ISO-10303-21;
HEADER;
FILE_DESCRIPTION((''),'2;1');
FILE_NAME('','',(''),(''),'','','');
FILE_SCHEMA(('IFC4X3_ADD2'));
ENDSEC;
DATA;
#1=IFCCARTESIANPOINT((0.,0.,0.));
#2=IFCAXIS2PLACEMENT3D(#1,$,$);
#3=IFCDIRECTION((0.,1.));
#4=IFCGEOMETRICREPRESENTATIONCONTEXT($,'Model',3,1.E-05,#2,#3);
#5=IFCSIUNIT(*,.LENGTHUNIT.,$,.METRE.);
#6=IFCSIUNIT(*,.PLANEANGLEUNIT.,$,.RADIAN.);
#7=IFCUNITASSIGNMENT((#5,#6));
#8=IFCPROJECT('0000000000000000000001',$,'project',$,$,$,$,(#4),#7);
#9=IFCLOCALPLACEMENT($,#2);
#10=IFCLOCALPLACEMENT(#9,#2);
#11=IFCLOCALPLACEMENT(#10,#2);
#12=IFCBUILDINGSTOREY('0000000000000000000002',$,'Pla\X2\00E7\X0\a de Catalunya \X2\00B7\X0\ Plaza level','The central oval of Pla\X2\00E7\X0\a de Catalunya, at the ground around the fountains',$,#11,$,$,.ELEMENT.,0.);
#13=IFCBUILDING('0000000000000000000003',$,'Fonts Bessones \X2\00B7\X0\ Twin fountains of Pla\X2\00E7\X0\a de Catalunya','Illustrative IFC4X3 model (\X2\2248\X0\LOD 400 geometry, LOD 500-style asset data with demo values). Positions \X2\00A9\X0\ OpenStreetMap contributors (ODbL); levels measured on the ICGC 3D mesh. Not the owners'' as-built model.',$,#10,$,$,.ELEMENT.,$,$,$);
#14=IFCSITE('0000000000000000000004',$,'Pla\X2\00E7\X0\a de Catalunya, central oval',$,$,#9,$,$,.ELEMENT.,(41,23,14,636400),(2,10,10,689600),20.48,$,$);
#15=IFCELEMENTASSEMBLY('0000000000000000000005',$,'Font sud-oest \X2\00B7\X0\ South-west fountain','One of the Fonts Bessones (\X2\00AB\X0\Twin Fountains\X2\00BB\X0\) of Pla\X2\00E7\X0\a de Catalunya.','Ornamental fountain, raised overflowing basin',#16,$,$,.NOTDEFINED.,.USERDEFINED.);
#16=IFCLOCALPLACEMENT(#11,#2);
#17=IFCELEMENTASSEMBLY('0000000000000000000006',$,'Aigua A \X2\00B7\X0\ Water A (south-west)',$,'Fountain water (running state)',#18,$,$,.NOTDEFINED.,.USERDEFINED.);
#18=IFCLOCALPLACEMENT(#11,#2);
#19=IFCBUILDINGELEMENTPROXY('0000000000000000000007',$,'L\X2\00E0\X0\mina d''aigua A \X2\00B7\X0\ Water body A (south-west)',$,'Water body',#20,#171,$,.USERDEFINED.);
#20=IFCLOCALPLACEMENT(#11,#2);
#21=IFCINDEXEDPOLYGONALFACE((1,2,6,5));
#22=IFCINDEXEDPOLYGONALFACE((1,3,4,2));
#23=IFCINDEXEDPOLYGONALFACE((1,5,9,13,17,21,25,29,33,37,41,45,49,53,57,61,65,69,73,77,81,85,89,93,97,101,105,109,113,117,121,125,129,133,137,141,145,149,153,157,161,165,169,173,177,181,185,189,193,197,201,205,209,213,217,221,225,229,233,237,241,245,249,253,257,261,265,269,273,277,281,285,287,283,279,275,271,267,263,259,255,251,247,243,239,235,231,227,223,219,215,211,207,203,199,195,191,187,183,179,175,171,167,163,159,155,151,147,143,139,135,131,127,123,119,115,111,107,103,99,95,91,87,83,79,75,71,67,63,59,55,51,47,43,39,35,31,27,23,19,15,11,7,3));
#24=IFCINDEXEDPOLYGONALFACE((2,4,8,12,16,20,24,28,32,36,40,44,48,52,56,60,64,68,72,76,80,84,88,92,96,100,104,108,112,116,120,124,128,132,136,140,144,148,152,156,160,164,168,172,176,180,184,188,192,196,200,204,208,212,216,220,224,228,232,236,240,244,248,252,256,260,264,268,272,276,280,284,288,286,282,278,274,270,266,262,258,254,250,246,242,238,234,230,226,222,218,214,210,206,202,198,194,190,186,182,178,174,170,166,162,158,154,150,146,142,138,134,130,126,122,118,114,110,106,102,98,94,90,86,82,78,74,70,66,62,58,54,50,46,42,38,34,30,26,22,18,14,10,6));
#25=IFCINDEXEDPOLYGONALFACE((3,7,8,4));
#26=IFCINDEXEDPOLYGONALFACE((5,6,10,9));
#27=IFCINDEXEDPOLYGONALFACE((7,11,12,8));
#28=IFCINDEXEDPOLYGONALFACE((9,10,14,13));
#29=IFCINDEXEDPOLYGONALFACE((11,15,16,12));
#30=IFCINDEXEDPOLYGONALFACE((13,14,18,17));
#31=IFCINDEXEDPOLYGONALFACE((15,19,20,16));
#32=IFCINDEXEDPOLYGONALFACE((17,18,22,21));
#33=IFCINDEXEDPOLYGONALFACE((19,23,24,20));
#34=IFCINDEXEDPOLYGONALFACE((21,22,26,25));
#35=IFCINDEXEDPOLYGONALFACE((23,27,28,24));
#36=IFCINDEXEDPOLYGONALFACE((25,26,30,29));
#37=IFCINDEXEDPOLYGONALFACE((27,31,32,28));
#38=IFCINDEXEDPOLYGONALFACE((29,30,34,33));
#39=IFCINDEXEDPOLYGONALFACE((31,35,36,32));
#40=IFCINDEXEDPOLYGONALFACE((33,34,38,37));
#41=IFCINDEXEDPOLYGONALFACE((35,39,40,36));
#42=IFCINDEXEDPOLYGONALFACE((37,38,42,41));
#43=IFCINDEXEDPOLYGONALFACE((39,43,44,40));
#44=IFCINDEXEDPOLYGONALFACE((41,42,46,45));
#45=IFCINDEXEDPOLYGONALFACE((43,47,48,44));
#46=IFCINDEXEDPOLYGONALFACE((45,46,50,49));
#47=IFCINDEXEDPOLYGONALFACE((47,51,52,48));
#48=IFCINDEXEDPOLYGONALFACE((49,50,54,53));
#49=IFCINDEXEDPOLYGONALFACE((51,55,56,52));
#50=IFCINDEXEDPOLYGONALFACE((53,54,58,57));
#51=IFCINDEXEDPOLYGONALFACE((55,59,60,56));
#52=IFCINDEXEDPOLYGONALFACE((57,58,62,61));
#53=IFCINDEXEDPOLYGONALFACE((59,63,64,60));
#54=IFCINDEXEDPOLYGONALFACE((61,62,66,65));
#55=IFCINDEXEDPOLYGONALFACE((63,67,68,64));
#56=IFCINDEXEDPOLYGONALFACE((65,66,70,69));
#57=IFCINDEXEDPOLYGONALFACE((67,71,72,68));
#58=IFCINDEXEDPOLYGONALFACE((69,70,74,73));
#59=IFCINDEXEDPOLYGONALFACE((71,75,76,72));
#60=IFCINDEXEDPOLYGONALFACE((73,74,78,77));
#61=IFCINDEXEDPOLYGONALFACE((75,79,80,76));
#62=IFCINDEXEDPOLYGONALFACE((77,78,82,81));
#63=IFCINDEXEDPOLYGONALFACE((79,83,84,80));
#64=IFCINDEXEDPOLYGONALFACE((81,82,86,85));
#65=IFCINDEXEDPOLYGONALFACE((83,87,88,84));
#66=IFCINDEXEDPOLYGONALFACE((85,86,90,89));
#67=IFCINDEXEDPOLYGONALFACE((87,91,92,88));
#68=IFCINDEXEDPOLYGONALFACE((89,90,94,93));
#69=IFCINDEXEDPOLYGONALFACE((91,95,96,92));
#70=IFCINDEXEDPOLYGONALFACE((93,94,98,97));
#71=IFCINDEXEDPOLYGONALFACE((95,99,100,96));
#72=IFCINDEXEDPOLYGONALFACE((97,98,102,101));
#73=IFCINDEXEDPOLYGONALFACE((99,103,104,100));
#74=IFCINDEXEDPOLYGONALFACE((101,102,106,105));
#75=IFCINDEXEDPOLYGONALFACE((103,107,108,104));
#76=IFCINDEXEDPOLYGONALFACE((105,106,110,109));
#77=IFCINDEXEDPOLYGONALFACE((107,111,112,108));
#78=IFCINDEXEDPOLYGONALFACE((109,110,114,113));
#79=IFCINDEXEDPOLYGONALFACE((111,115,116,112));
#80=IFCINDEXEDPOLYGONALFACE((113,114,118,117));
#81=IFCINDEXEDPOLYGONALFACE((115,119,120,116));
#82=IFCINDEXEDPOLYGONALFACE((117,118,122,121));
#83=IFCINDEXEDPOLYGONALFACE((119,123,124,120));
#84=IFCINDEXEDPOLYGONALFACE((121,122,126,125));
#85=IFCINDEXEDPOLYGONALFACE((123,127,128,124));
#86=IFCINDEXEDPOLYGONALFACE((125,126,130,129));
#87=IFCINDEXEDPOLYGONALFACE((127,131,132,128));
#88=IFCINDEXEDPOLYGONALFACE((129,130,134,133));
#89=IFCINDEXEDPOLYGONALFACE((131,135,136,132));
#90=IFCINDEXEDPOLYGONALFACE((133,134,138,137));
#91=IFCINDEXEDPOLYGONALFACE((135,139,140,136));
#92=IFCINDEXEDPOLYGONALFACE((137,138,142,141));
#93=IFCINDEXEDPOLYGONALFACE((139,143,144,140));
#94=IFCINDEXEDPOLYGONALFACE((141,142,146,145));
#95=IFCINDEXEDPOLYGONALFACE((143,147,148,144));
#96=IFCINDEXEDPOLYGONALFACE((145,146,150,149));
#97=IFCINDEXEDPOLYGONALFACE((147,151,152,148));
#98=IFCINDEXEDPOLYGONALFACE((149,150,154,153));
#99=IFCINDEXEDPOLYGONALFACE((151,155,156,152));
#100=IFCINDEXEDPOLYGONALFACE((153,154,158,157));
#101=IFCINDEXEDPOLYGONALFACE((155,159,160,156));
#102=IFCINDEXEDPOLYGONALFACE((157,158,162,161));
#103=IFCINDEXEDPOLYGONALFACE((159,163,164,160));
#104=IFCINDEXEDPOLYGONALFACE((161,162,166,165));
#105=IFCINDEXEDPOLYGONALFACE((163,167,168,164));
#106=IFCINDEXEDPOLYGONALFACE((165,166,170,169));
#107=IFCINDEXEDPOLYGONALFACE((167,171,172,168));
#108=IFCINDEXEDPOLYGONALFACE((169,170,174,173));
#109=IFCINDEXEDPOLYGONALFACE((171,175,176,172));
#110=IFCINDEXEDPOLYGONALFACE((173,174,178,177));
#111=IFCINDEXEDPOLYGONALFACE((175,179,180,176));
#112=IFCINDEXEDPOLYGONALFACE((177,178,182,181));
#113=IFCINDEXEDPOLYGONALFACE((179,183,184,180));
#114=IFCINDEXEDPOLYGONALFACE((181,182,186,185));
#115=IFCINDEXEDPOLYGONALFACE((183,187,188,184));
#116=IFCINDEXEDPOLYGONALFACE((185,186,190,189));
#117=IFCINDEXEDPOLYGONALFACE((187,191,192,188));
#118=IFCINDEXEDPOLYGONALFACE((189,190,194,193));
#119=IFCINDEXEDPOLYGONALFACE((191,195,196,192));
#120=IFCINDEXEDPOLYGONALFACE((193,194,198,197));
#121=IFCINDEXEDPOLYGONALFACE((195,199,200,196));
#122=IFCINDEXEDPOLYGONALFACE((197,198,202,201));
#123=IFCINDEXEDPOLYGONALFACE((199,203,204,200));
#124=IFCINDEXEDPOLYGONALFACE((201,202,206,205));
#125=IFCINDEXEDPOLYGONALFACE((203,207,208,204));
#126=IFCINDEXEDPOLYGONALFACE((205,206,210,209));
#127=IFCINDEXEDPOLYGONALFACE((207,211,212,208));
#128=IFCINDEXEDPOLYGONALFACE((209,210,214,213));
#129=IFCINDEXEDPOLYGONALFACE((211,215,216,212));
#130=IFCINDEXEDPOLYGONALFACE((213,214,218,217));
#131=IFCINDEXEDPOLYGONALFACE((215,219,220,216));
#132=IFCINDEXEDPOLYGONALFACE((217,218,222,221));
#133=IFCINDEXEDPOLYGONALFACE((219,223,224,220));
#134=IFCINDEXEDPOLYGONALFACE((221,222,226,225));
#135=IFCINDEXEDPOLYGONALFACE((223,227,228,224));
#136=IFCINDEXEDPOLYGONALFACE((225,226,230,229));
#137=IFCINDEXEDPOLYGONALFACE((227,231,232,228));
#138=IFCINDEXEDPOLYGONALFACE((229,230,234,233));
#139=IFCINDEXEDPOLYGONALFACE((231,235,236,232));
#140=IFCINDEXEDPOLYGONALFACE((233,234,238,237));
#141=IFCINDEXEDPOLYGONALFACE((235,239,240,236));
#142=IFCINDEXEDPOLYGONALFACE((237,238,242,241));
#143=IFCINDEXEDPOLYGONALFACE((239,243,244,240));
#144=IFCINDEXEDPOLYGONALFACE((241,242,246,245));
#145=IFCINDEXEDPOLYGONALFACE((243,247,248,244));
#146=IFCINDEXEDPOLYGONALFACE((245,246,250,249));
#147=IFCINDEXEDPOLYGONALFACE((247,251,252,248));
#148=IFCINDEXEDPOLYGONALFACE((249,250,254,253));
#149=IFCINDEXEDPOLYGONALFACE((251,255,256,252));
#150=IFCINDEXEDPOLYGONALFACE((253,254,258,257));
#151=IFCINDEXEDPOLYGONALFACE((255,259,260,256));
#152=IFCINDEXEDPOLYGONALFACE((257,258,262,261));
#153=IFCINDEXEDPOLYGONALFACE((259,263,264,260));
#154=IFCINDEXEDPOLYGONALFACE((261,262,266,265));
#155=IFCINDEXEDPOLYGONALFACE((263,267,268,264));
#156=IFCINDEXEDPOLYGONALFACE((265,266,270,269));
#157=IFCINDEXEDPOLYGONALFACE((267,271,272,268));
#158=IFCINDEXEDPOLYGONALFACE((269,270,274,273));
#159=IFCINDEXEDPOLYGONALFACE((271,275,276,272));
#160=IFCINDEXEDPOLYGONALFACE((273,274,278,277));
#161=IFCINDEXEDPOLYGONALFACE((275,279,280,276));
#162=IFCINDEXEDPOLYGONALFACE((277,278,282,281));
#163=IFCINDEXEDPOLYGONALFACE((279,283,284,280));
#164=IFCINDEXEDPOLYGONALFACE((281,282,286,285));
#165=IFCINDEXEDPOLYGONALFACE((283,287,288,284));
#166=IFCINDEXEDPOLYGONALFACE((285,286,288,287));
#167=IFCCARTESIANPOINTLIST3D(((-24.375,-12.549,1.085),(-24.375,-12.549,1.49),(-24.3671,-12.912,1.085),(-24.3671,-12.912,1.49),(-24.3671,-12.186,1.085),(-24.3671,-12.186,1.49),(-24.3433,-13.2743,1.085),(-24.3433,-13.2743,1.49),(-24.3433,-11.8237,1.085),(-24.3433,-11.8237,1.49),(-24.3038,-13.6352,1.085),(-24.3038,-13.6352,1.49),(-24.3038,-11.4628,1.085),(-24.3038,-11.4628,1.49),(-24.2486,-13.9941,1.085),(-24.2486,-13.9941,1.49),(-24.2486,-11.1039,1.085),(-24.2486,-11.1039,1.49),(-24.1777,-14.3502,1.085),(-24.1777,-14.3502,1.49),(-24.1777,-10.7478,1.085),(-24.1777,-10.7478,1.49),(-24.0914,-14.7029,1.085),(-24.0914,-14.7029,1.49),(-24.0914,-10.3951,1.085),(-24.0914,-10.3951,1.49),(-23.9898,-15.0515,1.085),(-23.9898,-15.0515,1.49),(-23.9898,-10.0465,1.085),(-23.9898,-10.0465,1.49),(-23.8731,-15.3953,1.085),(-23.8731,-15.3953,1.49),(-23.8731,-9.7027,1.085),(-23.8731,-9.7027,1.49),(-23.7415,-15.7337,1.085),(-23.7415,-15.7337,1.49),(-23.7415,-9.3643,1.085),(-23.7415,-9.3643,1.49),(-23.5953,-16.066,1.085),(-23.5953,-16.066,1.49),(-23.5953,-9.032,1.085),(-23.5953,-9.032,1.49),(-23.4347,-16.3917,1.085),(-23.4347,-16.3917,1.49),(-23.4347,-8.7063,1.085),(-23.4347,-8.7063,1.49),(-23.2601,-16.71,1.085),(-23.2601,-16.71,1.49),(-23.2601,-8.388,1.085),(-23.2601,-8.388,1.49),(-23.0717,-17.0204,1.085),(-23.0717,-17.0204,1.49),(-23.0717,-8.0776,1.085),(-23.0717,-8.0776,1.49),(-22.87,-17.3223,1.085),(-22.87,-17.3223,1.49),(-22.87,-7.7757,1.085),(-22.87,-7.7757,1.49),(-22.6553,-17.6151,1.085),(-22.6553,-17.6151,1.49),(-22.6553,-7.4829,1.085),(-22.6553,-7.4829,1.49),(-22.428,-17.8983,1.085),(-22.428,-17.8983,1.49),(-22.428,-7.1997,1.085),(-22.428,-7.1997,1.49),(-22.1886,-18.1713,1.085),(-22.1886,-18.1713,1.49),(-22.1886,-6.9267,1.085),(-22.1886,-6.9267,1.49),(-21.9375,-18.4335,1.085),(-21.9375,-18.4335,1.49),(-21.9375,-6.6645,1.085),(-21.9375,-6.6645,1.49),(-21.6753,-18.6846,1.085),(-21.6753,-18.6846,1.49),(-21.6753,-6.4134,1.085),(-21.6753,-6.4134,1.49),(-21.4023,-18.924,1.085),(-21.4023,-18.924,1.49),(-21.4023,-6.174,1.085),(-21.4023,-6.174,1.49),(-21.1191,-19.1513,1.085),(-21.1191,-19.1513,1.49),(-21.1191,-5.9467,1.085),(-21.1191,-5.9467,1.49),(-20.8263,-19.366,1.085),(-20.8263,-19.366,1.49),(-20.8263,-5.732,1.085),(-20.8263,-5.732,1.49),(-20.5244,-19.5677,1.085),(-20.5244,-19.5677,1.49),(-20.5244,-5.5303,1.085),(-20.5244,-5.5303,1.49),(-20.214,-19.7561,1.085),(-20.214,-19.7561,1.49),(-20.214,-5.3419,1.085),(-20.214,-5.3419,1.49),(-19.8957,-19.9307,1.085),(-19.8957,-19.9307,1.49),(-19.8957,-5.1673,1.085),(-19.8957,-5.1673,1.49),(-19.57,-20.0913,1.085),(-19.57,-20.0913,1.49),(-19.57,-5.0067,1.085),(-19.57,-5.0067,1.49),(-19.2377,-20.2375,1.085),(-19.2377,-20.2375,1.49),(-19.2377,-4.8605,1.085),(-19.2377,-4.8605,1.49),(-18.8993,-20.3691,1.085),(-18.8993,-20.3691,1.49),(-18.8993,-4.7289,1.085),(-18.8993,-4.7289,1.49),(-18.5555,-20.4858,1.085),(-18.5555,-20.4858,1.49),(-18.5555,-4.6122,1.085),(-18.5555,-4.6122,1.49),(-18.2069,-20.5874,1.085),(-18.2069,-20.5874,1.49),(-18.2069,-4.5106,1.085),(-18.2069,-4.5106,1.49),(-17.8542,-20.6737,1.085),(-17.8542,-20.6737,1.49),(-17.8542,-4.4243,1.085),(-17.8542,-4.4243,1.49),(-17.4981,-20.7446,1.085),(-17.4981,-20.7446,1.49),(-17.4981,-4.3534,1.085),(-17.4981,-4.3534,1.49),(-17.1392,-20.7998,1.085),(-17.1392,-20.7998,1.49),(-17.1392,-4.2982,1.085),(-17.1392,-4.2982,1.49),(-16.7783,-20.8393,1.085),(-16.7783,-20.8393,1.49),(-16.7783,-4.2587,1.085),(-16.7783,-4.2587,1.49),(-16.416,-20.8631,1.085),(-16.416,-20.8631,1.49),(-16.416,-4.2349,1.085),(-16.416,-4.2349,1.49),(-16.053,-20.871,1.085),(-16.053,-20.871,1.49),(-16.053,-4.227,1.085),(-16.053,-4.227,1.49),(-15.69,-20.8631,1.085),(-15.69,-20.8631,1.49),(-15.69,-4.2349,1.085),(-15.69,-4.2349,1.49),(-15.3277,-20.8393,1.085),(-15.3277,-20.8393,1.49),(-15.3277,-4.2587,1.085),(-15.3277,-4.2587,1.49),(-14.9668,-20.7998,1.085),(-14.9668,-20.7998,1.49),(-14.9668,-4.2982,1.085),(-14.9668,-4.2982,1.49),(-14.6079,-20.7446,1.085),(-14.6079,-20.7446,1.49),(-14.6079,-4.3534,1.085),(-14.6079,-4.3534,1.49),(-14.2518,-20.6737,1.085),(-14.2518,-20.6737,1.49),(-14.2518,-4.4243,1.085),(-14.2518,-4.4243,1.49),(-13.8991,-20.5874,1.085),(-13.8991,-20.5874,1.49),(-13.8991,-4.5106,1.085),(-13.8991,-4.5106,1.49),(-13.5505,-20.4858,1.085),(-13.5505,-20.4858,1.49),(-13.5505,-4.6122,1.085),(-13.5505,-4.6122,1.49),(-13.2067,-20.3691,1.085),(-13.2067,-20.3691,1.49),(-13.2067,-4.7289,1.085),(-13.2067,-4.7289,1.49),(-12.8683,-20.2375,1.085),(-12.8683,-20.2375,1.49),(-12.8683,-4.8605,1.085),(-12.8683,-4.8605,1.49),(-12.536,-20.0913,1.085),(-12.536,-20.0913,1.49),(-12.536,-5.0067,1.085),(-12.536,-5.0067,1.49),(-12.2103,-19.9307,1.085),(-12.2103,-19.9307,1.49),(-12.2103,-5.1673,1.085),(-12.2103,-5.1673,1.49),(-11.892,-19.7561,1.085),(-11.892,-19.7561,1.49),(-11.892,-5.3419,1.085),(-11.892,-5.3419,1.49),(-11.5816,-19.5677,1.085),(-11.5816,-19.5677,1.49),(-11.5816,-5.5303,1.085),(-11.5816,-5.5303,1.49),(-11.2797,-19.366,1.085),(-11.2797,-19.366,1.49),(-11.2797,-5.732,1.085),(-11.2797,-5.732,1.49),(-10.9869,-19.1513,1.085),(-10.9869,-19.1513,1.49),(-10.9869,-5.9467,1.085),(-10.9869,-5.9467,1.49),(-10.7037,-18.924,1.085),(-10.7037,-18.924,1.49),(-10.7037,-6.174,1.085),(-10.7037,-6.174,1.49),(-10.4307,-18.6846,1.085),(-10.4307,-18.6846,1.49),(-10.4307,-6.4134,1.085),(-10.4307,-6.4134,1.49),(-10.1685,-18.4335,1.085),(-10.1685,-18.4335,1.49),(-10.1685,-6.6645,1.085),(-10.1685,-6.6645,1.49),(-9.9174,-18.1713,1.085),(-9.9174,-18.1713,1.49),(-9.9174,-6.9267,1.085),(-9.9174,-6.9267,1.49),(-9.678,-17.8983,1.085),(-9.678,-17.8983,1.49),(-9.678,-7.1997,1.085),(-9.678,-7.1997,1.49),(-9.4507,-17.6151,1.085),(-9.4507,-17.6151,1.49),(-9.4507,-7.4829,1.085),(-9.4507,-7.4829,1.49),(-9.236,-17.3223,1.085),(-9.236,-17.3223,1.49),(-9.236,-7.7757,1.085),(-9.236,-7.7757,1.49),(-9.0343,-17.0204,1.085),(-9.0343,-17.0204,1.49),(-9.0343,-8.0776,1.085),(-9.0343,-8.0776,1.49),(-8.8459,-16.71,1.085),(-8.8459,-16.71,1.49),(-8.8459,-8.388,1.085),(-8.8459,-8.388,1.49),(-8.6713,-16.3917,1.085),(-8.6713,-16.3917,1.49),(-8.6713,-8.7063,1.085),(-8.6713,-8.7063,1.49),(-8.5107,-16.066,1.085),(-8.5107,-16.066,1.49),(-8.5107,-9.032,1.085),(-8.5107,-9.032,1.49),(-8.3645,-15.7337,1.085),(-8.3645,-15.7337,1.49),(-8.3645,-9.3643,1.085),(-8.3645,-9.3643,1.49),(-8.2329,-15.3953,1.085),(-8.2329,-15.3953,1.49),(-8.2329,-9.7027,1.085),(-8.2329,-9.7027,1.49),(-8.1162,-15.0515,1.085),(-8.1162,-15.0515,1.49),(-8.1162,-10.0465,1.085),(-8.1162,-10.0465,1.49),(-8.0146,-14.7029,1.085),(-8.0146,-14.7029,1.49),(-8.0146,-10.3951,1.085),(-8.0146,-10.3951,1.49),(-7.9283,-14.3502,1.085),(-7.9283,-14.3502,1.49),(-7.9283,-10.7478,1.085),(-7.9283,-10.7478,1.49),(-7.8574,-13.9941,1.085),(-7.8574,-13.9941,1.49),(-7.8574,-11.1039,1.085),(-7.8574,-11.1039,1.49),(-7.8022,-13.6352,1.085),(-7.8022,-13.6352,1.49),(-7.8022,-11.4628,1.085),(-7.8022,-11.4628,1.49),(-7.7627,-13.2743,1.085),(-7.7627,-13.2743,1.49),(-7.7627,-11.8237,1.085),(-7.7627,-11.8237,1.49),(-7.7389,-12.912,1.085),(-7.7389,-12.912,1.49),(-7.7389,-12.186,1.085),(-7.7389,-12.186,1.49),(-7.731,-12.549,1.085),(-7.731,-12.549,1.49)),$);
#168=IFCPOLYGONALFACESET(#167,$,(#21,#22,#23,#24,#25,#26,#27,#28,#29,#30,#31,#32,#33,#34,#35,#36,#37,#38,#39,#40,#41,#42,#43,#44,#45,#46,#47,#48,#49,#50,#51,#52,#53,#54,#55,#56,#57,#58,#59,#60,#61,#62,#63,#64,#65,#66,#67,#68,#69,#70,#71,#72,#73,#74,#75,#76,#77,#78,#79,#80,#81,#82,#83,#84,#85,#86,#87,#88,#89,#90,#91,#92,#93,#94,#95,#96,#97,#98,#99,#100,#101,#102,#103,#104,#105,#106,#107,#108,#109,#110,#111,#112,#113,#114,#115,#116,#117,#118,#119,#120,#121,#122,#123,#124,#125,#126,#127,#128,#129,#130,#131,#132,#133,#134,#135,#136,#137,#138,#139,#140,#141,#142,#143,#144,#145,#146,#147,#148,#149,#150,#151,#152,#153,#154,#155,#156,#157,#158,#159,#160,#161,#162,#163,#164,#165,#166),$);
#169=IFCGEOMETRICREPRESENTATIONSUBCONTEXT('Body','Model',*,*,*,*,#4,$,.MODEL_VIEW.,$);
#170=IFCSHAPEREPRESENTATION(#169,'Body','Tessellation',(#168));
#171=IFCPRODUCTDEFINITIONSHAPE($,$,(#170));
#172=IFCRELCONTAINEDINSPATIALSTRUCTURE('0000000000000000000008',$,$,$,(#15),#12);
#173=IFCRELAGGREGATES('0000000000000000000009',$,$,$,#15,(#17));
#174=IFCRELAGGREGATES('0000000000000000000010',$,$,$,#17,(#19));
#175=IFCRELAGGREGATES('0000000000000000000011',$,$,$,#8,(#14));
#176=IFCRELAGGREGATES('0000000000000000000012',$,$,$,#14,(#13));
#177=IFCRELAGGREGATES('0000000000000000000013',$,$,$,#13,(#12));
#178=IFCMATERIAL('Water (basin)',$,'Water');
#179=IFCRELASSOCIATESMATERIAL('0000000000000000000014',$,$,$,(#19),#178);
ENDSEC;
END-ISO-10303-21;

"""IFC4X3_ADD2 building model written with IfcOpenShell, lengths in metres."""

from ifc_helpers import new_model, si_unit, direction, frame, origin, origin_2d_with_axis, place, context, subcontext, project, spatial, circle, extrude, material, element, aggregate, save


model = new_model("IFC4X3_ADD2")

# Units and contexts
model_context = context("Model", 3, precision=1e-05, world=origin(), true_north=direction((0.0, 1.0)))
body_context = subcontext(model_context, "Body", "Model", "MODEL_VIEW")
ifc_project = project(units=[si_unit("LENGTHUNIT", "METRE"), si_unit("PLANEANGLEUNIT", "RADIAN")], contexts=[model_context])

# Site, building, storey
site_placement = place(None, origin())
site = spatial("IfcSite", under=ifc_project, at=site_placement, Name="Plaça de Catalunya, central oval", CompositionType="ELEMENT", RefLatitude=(41, 23, 14, 636400), RefLongitude=(2, 10, 10, 689600), RefElevation=20.48)
building_placement = place(site_placement, origin())
building = spatial("IfcBuilding", under=site, at=building_placement, Name="Fonts Bessones · Twin fountains of Plaça de Catalunya", Description="Illustrative IFC4X3 model (≈LOD 400 geometry, LOD 500-style asset data with demo values). Positions © OpenStreetMap contributors (ODbL); levels measured on the ICGC 3D mesh. Not the owners' as-built model.", CompositionType="ELEMENT")
storey_placement = place(building_placement, origin())
storey = spatial("IfcBuildingStorey", under=building, at=storey_placement, Name="Plaça de Catalunya · Plaza level", Description="The central oval of Plaça de Catalunya, at the ground around the fountains", CompositionType="ELEMENT", Elevation=0.0)

# Element assemblies, building element proxy
assembly_1_placement = place(building_placement, origin())
assembly_1 = element("IfcElementAssembly", 1, at=assembly_1_placement, inside=storey, Name="Font sud-oest · South-west fountain", Description="One of the Fonts Bessones («Twin Fountains») of Plaça de Catalunya.", ObjectType="Ornamental fountain, raised overflowing basin", AssemblyPlace="NOTDEFINED", PredefinedType="USERDEFINED")
assembly_2_placement = place(building_placement, origin())
assembly_2 = element("IfcElementAssembly", 2, at=assembly_2_placement, Name="Aigua A · Water A (south-west)", ObjectType="Fountain water (running state)", AssemblyPlace="NOTDEFINED", PredefinedType="USERDEFINED")
aggregate(assembly_1, [assembly_2])
ifc_material_1 = material(Name="Water (basin)", Category="Water")
proxy_1_placement = place(building_placement, origin())
proxy_1 = element("IfcBuildingElementProxy", 3, at=proxy_1_placement, material=ifc_material_1, Name="Làmina d'aigua A · Water body A (south-west)", ObjectType="Water body", PredefinedType="USERDEFINED", context=body_context, shape_type="SweptSolid", body=[
    extrude(circle(Radius=8.322, at=origin_2d_with_axis()), frame((-16.053, -12.549, 1.085)), (0.0, 0.0, 1.0), 0.405),
])
aggregate(assembly_2, [proxy_1])

save(model, "model.ifc")
